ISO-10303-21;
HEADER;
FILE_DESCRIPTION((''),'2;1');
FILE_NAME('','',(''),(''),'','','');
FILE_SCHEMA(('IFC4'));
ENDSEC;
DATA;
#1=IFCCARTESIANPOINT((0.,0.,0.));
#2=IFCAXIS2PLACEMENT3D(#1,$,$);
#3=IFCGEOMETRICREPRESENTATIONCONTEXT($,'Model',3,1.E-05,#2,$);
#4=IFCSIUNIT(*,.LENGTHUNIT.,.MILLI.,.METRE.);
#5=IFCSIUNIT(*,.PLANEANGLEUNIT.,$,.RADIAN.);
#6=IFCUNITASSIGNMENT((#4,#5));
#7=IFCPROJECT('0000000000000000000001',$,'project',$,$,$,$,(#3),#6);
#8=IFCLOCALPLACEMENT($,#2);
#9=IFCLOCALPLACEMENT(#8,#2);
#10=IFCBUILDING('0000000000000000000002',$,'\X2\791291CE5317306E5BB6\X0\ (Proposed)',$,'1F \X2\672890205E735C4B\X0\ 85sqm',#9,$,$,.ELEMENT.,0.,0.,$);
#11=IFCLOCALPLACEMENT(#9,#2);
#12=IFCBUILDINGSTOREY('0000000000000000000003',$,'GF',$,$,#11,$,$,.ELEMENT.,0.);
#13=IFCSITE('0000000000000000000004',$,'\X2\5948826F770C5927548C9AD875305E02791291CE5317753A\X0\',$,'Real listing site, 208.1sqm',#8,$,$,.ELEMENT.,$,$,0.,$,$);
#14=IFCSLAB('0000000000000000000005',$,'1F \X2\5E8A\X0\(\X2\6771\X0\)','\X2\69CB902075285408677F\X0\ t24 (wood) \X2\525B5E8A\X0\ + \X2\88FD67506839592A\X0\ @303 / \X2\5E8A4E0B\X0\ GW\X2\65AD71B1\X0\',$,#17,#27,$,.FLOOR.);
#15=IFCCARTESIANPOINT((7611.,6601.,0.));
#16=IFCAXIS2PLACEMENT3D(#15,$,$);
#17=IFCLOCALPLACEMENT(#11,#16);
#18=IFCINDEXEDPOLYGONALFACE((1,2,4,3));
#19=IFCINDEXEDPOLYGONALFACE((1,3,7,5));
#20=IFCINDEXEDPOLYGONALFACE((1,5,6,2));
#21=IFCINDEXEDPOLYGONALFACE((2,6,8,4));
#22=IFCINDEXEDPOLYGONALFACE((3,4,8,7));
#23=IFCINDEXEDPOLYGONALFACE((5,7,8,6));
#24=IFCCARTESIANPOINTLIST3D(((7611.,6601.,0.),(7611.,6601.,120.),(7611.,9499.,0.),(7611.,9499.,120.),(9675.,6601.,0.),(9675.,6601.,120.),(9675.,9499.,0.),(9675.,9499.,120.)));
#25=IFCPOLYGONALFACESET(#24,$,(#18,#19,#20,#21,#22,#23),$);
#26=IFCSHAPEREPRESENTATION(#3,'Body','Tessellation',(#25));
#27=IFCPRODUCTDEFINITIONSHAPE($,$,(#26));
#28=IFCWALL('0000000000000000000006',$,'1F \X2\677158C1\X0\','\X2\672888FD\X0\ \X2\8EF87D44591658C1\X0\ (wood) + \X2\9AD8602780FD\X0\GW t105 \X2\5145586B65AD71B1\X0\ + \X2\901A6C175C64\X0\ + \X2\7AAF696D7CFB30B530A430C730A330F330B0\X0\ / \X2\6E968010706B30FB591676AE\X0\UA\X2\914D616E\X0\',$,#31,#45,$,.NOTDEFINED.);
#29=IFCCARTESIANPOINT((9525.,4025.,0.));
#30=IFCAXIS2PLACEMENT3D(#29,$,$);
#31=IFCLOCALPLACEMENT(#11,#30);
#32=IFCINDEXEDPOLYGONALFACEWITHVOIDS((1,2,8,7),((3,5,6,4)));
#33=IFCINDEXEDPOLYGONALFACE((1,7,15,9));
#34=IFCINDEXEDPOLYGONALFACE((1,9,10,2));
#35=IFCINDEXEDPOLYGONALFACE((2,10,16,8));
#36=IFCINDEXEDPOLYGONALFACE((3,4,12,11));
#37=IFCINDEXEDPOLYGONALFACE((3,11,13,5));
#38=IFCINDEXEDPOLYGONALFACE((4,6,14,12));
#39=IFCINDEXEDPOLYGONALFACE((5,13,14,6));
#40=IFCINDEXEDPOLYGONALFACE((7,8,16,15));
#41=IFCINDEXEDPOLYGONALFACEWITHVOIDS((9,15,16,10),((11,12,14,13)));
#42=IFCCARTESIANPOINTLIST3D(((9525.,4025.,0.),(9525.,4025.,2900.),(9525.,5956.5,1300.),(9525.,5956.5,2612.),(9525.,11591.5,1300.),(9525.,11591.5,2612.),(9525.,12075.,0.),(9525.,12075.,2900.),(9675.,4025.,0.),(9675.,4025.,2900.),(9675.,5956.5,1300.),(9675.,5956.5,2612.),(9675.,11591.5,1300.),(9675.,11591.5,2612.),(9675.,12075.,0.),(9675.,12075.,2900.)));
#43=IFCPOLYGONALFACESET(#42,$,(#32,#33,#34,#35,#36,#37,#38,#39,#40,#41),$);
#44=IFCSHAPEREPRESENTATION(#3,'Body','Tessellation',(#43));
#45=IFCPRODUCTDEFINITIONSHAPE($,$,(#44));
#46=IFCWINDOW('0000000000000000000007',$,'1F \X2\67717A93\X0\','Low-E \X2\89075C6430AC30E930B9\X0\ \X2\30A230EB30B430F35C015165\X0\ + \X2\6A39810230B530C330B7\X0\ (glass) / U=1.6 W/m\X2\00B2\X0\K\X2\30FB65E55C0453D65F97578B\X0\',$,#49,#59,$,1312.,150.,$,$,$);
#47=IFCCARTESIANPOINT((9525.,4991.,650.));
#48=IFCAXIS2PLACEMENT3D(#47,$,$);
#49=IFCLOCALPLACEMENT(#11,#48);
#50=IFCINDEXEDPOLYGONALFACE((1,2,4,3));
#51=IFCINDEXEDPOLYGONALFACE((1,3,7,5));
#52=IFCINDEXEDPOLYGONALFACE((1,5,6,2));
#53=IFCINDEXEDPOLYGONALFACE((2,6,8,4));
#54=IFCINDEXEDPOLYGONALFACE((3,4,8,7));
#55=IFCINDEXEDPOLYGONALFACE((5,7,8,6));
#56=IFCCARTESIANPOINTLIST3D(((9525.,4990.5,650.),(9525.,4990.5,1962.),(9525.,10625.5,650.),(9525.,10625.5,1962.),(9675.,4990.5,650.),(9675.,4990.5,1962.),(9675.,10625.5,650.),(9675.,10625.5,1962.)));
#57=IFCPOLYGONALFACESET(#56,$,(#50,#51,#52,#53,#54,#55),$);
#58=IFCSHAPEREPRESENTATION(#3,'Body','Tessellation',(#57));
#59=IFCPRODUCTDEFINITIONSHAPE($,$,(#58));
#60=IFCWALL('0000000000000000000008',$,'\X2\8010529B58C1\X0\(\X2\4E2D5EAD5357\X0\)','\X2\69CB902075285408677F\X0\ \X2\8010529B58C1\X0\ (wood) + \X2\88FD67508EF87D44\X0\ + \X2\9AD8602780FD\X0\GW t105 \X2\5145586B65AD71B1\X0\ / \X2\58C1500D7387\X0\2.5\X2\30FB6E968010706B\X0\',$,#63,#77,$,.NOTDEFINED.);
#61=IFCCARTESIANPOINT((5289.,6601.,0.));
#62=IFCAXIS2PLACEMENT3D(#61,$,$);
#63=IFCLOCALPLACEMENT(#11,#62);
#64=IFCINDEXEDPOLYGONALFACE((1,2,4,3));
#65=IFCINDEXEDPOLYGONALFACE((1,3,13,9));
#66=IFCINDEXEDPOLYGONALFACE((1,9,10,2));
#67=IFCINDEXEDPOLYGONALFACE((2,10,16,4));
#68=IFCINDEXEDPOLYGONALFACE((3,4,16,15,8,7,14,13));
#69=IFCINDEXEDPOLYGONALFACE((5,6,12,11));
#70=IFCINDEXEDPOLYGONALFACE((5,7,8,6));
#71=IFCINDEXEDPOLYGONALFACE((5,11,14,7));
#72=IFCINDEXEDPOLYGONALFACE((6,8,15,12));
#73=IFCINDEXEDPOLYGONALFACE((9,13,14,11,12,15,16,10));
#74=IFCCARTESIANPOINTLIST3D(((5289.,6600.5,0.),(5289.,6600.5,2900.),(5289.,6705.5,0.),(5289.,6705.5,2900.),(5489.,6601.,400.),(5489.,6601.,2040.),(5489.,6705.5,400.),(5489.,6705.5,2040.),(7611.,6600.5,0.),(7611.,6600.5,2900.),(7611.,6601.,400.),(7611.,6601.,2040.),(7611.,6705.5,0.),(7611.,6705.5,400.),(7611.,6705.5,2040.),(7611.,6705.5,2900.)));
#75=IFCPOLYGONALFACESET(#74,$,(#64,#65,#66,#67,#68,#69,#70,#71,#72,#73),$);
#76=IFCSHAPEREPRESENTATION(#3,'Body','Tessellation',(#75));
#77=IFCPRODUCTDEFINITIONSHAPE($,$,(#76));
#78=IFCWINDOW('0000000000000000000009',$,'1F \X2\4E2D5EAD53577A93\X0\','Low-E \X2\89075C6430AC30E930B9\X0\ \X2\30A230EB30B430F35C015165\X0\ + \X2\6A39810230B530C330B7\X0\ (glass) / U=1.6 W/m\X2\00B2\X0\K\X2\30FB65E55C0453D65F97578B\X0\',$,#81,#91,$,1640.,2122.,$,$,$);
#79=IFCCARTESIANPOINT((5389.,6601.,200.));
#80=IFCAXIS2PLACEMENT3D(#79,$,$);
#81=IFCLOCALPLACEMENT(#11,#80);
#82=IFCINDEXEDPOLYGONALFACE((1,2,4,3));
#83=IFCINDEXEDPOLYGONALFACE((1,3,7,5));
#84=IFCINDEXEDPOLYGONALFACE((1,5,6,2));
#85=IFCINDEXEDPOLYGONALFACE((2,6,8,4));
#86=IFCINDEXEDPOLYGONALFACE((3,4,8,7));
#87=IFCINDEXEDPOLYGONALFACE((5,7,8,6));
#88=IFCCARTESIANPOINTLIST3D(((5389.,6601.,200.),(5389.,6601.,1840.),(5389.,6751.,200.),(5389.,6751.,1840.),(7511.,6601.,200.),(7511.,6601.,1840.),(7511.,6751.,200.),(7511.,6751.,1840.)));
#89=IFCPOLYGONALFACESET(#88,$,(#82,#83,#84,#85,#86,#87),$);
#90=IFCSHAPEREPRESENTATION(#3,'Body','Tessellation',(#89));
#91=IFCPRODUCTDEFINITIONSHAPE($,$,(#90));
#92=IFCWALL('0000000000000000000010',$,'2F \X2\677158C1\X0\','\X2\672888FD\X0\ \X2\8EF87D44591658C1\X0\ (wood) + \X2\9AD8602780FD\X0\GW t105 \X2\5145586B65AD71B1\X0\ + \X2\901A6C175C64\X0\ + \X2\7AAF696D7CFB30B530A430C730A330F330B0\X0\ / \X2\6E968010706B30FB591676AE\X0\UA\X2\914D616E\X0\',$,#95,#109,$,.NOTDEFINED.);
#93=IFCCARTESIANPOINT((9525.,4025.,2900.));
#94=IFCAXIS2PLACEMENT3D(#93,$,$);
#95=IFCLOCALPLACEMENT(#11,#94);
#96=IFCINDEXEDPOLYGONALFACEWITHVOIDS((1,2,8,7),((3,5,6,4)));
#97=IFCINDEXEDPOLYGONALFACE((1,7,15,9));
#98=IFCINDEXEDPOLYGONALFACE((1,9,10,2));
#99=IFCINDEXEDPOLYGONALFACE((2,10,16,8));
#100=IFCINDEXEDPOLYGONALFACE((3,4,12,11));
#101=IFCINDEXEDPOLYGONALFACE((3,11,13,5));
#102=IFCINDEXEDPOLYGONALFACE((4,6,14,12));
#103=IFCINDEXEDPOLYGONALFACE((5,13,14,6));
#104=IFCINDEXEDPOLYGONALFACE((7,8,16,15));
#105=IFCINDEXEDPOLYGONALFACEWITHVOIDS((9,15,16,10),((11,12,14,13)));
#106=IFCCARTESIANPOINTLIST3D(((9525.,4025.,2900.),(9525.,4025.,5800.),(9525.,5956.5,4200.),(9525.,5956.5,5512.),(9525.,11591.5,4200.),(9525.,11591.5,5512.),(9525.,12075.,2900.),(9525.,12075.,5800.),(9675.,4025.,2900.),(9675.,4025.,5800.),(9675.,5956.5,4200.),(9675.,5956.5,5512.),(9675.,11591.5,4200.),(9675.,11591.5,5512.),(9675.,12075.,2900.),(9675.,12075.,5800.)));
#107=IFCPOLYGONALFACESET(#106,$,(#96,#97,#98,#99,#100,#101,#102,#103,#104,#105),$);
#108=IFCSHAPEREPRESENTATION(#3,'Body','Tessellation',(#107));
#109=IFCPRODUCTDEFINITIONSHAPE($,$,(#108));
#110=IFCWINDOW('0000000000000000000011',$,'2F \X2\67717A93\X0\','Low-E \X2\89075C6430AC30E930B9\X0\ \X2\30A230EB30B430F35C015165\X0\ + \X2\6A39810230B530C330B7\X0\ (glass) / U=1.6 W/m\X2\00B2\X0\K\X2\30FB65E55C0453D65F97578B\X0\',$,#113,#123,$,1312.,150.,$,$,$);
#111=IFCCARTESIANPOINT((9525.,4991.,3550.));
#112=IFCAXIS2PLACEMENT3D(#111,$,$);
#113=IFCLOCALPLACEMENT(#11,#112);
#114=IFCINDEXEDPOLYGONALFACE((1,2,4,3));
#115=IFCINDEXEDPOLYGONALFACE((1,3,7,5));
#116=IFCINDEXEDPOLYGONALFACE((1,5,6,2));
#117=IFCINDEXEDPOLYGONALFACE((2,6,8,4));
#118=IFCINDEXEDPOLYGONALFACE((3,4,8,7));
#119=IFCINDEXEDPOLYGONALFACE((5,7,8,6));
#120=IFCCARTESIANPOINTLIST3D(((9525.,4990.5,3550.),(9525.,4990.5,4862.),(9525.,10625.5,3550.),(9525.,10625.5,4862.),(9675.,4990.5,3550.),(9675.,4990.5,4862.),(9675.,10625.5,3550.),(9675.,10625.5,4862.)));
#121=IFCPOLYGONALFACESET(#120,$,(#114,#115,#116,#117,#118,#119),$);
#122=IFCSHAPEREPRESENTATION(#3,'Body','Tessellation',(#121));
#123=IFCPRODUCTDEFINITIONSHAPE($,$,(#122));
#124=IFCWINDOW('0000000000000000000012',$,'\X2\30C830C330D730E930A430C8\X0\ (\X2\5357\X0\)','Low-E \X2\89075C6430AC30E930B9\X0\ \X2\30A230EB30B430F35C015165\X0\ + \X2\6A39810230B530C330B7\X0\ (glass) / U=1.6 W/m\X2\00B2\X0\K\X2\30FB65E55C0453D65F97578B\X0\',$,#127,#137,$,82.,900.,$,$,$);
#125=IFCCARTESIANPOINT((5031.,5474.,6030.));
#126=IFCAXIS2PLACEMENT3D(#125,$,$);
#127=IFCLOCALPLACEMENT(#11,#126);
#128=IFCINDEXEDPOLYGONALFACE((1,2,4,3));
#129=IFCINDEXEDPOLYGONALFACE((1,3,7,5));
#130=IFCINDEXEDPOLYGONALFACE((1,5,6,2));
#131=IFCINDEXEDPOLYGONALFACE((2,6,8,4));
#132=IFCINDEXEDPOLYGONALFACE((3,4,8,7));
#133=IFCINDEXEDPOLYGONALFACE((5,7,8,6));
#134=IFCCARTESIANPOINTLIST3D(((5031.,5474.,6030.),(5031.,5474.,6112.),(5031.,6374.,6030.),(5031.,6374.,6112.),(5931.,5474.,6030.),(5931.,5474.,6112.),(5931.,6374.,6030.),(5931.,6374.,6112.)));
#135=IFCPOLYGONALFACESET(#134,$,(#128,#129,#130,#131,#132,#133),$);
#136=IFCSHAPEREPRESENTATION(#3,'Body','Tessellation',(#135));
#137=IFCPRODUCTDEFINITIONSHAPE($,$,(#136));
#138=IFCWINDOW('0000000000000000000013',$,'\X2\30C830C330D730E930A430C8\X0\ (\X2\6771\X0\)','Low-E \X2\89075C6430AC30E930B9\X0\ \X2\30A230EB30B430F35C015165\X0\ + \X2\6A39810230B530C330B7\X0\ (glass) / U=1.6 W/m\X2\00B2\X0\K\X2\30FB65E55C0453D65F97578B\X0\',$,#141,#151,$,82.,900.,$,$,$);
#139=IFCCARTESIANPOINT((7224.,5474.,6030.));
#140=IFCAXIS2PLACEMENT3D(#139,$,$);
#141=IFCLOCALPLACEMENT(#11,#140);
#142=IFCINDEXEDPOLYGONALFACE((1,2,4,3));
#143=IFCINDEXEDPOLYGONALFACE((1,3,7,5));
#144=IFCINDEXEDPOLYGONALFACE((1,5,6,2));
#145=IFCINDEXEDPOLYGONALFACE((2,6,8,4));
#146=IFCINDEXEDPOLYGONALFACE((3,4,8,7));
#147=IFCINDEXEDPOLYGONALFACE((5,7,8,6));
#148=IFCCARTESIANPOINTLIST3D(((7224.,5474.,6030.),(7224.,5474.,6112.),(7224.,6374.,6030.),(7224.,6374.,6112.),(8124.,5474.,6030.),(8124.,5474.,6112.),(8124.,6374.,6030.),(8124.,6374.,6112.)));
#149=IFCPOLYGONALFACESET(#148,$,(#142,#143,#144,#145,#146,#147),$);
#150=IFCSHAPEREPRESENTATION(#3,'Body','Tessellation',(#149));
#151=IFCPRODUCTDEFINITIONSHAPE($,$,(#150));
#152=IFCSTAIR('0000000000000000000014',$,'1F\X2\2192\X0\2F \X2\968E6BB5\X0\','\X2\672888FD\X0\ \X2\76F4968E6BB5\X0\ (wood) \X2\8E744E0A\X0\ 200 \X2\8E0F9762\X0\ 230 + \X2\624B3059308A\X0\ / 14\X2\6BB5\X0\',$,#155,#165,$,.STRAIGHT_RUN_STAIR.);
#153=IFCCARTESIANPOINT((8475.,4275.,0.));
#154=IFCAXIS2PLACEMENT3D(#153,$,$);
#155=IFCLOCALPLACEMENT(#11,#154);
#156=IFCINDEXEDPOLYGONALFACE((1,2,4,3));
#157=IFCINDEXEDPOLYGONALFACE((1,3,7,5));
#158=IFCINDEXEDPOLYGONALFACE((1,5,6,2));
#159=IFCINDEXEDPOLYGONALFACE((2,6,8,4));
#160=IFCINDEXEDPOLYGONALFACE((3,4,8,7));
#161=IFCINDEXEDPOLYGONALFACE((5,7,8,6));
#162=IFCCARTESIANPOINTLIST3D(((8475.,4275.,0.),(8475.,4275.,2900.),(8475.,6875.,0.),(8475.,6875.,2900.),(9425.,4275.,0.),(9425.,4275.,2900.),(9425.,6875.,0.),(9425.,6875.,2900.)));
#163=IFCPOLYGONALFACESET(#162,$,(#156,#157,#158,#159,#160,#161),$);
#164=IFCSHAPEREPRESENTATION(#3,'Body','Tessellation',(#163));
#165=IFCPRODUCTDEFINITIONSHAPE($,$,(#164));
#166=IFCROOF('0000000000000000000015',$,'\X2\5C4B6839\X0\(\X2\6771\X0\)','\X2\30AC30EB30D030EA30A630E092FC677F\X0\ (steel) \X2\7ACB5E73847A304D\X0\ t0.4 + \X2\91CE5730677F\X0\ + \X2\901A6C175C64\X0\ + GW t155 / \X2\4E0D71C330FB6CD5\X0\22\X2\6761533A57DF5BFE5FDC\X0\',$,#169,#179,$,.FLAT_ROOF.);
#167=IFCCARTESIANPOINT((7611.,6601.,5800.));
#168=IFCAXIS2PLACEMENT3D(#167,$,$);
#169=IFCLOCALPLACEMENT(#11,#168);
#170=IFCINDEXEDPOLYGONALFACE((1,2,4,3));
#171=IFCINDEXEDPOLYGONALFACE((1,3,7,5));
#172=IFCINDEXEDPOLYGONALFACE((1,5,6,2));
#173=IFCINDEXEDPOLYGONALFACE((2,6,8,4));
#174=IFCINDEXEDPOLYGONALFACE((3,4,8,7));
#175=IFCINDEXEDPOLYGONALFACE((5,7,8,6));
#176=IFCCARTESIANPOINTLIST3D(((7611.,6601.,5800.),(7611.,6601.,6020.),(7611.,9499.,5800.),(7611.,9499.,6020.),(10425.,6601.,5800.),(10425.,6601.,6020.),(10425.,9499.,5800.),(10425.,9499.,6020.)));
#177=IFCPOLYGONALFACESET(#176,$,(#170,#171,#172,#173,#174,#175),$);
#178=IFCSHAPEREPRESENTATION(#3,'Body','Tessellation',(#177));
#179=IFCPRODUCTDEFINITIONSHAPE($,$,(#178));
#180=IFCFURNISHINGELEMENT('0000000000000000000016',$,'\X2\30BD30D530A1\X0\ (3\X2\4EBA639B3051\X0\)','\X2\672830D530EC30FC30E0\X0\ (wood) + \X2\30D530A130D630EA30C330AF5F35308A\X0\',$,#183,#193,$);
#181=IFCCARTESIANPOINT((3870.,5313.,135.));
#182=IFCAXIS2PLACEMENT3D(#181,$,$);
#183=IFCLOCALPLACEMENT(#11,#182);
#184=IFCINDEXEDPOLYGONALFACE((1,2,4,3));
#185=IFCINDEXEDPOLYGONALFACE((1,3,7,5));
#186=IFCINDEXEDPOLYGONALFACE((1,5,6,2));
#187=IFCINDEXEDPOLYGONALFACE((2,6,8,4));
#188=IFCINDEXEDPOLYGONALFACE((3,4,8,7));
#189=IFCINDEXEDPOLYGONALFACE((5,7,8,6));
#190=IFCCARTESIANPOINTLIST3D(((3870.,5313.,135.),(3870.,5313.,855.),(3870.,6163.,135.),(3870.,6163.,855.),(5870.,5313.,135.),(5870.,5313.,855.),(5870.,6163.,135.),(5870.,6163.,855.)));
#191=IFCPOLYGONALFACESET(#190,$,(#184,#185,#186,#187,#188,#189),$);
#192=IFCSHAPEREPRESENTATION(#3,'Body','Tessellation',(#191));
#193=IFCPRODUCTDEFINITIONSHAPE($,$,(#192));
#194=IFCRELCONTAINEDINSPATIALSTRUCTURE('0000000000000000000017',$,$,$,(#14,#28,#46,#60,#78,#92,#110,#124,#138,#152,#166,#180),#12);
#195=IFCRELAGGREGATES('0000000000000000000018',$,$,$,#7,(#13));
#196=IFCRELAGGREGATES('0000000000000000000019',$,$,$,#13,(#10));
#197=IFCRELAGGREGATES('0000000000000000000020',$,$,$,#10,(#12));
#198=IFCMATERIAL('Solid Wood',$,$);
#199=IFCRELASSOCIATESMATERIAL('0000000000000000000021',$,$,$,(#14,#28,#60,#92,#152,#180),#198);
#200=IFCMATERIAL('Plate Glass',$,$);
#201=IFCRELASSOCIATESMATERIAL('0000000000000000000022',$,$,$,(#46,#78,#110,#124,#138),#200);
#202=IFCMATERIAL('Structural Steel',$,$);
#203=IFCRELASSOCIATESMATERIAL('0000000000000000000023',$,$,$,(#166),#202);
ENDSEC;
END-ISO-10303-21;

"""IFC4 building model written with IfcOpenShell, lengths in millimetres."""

from ifc_helpers import new_model, si_unit, frame, frame_2d, origin, place, context, project, spatial, rectangle, extrude, material, element, fill, save


model = new_model("IFC4")

# Units and contexts
model_context = context("Model", 3, precision=1e-05, world=origin())
ifc_project = project(units=[si_unit("LENGTHUNIT", "METRE", prefix="MILLI"), si_unit("PLANEANGLEUNIT", "RADIAN")], contexts=[model_context])

# Site, building, storey
site_placement = place(None, origin())
site = spatial("IfcSite", under=ifc_project, at=site_placement, Name="奈良県大和高田市礒野北町", ObjectType="Real listing site, 208.1sqm", CompositionType="ELEMENT", RefElevation=0.0)
building_placement = place(site_placement, origin())
building = spatial("IfcBuilding", under=site, at=building_placement, Name="礒野北の家 (Proposed)", ObjectType="1F 木造平屋 85sqm", CompositionType="ELEMENT", ElevationOfRefHeight=0.0, ElevationOfTerrain=0.0)
storey_placement = place(building_placement, origin())
storey = spatial("IfcBuildingStorey", under=building, at=storey_placement, Name="GF", CompositionType="ELEMENT", Elevation=0.0)

# Slab
ifc_material_1 = material(Name="Solid Wood")
slab_placement = place(storey_placement, frame((7611.0, 6601.0, 0.0)))
element("IfcSlab", 1, at=slab_placement, inside=storey, material=ifc_material_1, Name="1F 床(東)", Description="構造用合板 t24 (wood) 剛床 + 製材根太 @303 / 床下 GW断熱", PredefinedType="FLOOR", context=model_context, shape_type="SweptSolid", body=[
    extrude(rectangle(XDim=2064.0, YDim=2898.0, at=frame_2d((1032.0, 1449.0))), frame((7611.0, 6601.0, 0.0)), (0.0, 0.0, 1.0), 120.0),
])

# Walls, openings, windows
wall_1_placement = place(storey_placement, frame((9525.0, 4025.0, 0.0)))
wall_1 = element("IfcWall", 2, at=wall_1_placement, inside=storey, material=ifc_material_1, Name="1F 東壁", Description="木製 軸組外壁 (wood) + 高性能GW t105 充填断熱 + 通気層 + 窯業系サイディング / 準耐火・外皮UA配慮", PredefinedType="NOTDEFINED", context=model_context, shape_type="SweptSolid", body=[
    extrude(rectangle(XDim=150.0, YDim=8050.0, at=frame_2d((75.0, 4025.0))), frame((9525.0, 4025.0, 0.0)), (0.0, 0.0, 1.0), 2900.0),
])
opening_1_placement = place(storey_placement, frame((9525.0, 4991.0, 650.0)))
opening_1 = element("IfcOpeningElement", 3, at=opening_1_placement, cuts=wall_1, PredefinedType="NOTDEFINED", context=model_context, shape_type="SweptSolid", body=[
    extrude(rectangle(XDim=150.0, YDim=5635.0, at=frame_2d((75.0, 2817.0))), frame((9525.0, 4991.0, 650.0)), (0.0, 0.0, 1.0), 1312.0),
])
ifc_material_2 = material(Name="Plate Glass")
window_1_placement = place(storey_placement, frame((9525.0, 4991.0, 650.0)))
window_1 = element("IfcWindow", 4, at=window_1_placement, inside=storey, material=ifc_material_2, Name="1F 東窓", Description="Low-E 複層ガラス アルゴン封入 + 樹脂サッシ (glass) / U=1.6 W/m²K・日射取得型", OverallHeight=1312.0, OverallWidth=150.0, context=model_context, shape_type="SweptSolid", body=[
    extrude(rectangle(XDim=150.0, YDim=5635.0, at=frame_2d((75.0, 2817.0))), frame((9525.0, 4991.0, 650.0)), (0.0, 0.0, 1.0), 1312.0),
])
fill(opening_1, window_1)
wall_2_placement = place(storey_placement, frame((5289.0, 6601.0, 0.0)))
wall_2 = element("IfcWall", 5, at=wall_2_placement, inside=storey, material=ifc_material_1, Name="耐力壁(中庭南)", Description="構造用合板 耐力壁 (wood) + 製材軸組 + 高性能GW t105 充填断熱 / 壁倍率2.5・準耐火", PredefinedType="NOTDEFINED", context=model_context, shape_type="SweptSolid", body=[
    extrude(rectangle(XDim=2322.0, YDim=105.0, at=frame_2d((1161.0, 52.0))), frame((5289.0, 6601.0, 0.0)), (0.0, 0.0, 1.0), 2900.0),
])
opening_2_placement = place(storey_placement, frame((5389.0, 6601.0, 200.0)))
opening_2 = element("IfcOpeningElement", 6, at=opening_2_placement, cuts=wall_2, PredefinedType="NOTDEFINED", context=model_context, shape_type="SweptSolid", body=[
    extrude(rectangle(XDim=2122.0, YDim=150.0, at=frame_2d((1061.0, 75.0))), frame((5389.0, 6601.0, 200.0)), (0.0, 0.0, 1.0), 1640.0),
])
window_2_placement = place(storey_placement, frame((5389.0, 6601.0, 200.0)))
window_2 = element("IfcWindow", 7, at=window_2_placement, inside=storey, material=ifc_material_2, Name="1F 中庭南窓", Description="Low-E 複層ガラス アルゴン封入 + 樹脂サッシ (glass) / U=1.6 W/m²K・日射取得型", OverallHeight=1640.0, OverallWidth=2122.0, context=model_context, shape_type="SweptSolid", body=[
    extrude(rectangle(XDim=2122.0, YDim=150.0, at=frame_2d((1061.0, 75.0))), frame((5389.0, 6601.0, 200.0)), (0.0, 0.0, 1.0), 1640.0),
])
fill(opening_2, window_2)

# Wall, opening, window
wall_3_placement = place(storey_placement, frame((9525.0, 4025.0, 2900.0)))
wall_3 = element("IfcWall", 8, at=wall_3_placement, inside=storey, material=ifc_material_1, Name="2F 東壁", Description="木製 軸組外壁 (wood) + 高性能GW t105 充填断熱 + 通気層 + 窯業系サイディング / 準耐火・外皮UA配慮", PredefinedType="NOTDEFINED", context=model_context, shape_type="SweptSolid", body=[
    extrude(rectangle(XDim=150.0, YDim=8050.0, at=frame_2d((75.0, 4025.0))), frame((9525.0, 4025.0, 2900.0)), (0.0, 0.0, 1.0), 2900.0),
])
opening_3_placement = place(storey_placement, frame((9525.0, 4991.0, 3550.0)))
opening_3 = element("IfcOpeningElement", 9, at=opening_3_placement, cuts=wall_3, PredefinedType="NOTDEFINED", context=model_context, shape_type="SweptSolid", body=[
    extrude(rectangle(XDim=150.0, YDim=5635.0, at=frame_2d((75.0, 2817.0))), frame((9525.0, 4991.0, 3550.0)), (0.0, 0.0, 1.0), 1312.0),
])
window_3_placement = place(storey_placement, frame((9525.0, 4991.0, 3550.0)))
window_3 = element("IfcWindow", 10, at=window_3_placement, inside=storey, material=ifc_material_2, Name="2F 東窓", Description="Low-E 複層ガラス アルゴン封入 + 樹脂サッシ (glass) / U=1.6 W/m²K・日射取得型", OverallHeight=1312.0, OverallWidth=150.0, context=model_context, shape_type="SweptSolid", body=[
    extrude(rectangle(XDim=150.0, YDim=5635.0, at=frame_2d((75.0, 2817.0))), frame((9525.0, 4991.0, 3550.0)), (0.0, 0.0, 1.0), 1312.0),
])
fill(opening_3, window_3)

# Windows
window_4_placement = place(storey_placement, frame((5031.0, 5474.0, 6030.0)))
element("IfcWindow", 11, at=window_4_placement, inside=storey, material=ifc_material_2, Name="トップライト (南)", Description="Low-E 複層ガラス アルゴン封入 + 樹脂サッシ (glass) / U=1.6 W/m²K・日射取得型", OverallHeight=82.0, OverallWidth=900.0, context=model_context, shape_type="SweptSolid", body=[
    extrude(rectangle(XDim=900.0, YDim=900.0, at=frame_2d((450.0, 450.0))), frame((5031.0, 5474.0, 6030.0)), (0.0, 0.0, 1.0), 82.0),
])
window_5_placement = place(storey_placement, frame((7224.0, 5474.0, 6030.0)))
element("IfcWindow", 12, at=window_5_placement, inside=storey, material=ifc_material_2, Name="トップライト (東)", Description="Low-E 複層ガラス アルゴン封入 + 樹脂サッシ (glass) / U=1.6 W/m²K・日射取得型", OverallHeight=82.0, OverallWidth=900.0, context=model_context, shape_type="SweptSolid", body=[
    extrude(rectangle(XDim=900.0, YDim=900.0, at=frame_2d((450.0, 450.0))), frame((7224.0, 5474.0, 6030.0)), (0.0, 0.0, 1.0), 82.0),
])

# Stair
stair_placement = place(storey_placement, frame((8475.0, 4275.0, 0.0)))
element("IfcStair", 13, at=stair_placement, inside=storey, material=ifc_material_1, Name="1F→2F 階段", Description="木製 直階段 (wood) 蹴上 200 踏面 230 + 手すり / 14段", PredefinedType="STRAIGHT_RUN_STAIR", context=model_context, shape_type="SweptSolid", body=[
    extrude(rectangle(XDim=950.0, YDim=2600.0, at=frame_2d((475.0, 1300.0))), frame((8475.0, 4275.0, 0.0)), (0.0, 0.0, 1.0), 2900.0),
])

# Roof
ifc_material_3 = material(Name="Structural Steel")
roof_placement = place(storey_placement, frame((7611.0, 6601.0, 5800.0)))
element("IfcRoof", 14, at=roof_placement, inside=storey, material=ifc_material_3, Name="屋根(東)", Description="ガルバリウム鋼板 (steel) 立平葺き t0.4 + 野地板 + 通気層 + GW t155 / 不燃・法22条区域対応", PredefinedType="FLAT_ROOF", context=model_context, shape_type="SweptSolid", body=[
    extrude(rectangle(XDim=2814.0, YDim=2898.0, at=frame_2d((1407.0, 1449.0))), frame((7611.0, 6601.0, 5800.0)), (0.0, 0.0, 1.0), 220.0),
])

# Furnishing element
furnishing_1_placement = place(storey_placement, frame((3870.0, 5313.0, 135.0)))
element("IfcFurnishingElement", 15, at=furnishing_1_placement, inside=storey, material=ifc_material_1, Name="ソファ (3人掛け)", Description="木フレーム (wood) + ファブリック張り", context=model_context, shape_type="SweptSolid", body=[
    extrude(rectangle(XDim=2000.0, YDim=850.0, at=frame_2d((1000.0, 425.0))), frame((3870.0, 5313.0, 135.0)), (0.0, 0.0, 1.0), 720.0),
])

save(model, "model.ifc")
